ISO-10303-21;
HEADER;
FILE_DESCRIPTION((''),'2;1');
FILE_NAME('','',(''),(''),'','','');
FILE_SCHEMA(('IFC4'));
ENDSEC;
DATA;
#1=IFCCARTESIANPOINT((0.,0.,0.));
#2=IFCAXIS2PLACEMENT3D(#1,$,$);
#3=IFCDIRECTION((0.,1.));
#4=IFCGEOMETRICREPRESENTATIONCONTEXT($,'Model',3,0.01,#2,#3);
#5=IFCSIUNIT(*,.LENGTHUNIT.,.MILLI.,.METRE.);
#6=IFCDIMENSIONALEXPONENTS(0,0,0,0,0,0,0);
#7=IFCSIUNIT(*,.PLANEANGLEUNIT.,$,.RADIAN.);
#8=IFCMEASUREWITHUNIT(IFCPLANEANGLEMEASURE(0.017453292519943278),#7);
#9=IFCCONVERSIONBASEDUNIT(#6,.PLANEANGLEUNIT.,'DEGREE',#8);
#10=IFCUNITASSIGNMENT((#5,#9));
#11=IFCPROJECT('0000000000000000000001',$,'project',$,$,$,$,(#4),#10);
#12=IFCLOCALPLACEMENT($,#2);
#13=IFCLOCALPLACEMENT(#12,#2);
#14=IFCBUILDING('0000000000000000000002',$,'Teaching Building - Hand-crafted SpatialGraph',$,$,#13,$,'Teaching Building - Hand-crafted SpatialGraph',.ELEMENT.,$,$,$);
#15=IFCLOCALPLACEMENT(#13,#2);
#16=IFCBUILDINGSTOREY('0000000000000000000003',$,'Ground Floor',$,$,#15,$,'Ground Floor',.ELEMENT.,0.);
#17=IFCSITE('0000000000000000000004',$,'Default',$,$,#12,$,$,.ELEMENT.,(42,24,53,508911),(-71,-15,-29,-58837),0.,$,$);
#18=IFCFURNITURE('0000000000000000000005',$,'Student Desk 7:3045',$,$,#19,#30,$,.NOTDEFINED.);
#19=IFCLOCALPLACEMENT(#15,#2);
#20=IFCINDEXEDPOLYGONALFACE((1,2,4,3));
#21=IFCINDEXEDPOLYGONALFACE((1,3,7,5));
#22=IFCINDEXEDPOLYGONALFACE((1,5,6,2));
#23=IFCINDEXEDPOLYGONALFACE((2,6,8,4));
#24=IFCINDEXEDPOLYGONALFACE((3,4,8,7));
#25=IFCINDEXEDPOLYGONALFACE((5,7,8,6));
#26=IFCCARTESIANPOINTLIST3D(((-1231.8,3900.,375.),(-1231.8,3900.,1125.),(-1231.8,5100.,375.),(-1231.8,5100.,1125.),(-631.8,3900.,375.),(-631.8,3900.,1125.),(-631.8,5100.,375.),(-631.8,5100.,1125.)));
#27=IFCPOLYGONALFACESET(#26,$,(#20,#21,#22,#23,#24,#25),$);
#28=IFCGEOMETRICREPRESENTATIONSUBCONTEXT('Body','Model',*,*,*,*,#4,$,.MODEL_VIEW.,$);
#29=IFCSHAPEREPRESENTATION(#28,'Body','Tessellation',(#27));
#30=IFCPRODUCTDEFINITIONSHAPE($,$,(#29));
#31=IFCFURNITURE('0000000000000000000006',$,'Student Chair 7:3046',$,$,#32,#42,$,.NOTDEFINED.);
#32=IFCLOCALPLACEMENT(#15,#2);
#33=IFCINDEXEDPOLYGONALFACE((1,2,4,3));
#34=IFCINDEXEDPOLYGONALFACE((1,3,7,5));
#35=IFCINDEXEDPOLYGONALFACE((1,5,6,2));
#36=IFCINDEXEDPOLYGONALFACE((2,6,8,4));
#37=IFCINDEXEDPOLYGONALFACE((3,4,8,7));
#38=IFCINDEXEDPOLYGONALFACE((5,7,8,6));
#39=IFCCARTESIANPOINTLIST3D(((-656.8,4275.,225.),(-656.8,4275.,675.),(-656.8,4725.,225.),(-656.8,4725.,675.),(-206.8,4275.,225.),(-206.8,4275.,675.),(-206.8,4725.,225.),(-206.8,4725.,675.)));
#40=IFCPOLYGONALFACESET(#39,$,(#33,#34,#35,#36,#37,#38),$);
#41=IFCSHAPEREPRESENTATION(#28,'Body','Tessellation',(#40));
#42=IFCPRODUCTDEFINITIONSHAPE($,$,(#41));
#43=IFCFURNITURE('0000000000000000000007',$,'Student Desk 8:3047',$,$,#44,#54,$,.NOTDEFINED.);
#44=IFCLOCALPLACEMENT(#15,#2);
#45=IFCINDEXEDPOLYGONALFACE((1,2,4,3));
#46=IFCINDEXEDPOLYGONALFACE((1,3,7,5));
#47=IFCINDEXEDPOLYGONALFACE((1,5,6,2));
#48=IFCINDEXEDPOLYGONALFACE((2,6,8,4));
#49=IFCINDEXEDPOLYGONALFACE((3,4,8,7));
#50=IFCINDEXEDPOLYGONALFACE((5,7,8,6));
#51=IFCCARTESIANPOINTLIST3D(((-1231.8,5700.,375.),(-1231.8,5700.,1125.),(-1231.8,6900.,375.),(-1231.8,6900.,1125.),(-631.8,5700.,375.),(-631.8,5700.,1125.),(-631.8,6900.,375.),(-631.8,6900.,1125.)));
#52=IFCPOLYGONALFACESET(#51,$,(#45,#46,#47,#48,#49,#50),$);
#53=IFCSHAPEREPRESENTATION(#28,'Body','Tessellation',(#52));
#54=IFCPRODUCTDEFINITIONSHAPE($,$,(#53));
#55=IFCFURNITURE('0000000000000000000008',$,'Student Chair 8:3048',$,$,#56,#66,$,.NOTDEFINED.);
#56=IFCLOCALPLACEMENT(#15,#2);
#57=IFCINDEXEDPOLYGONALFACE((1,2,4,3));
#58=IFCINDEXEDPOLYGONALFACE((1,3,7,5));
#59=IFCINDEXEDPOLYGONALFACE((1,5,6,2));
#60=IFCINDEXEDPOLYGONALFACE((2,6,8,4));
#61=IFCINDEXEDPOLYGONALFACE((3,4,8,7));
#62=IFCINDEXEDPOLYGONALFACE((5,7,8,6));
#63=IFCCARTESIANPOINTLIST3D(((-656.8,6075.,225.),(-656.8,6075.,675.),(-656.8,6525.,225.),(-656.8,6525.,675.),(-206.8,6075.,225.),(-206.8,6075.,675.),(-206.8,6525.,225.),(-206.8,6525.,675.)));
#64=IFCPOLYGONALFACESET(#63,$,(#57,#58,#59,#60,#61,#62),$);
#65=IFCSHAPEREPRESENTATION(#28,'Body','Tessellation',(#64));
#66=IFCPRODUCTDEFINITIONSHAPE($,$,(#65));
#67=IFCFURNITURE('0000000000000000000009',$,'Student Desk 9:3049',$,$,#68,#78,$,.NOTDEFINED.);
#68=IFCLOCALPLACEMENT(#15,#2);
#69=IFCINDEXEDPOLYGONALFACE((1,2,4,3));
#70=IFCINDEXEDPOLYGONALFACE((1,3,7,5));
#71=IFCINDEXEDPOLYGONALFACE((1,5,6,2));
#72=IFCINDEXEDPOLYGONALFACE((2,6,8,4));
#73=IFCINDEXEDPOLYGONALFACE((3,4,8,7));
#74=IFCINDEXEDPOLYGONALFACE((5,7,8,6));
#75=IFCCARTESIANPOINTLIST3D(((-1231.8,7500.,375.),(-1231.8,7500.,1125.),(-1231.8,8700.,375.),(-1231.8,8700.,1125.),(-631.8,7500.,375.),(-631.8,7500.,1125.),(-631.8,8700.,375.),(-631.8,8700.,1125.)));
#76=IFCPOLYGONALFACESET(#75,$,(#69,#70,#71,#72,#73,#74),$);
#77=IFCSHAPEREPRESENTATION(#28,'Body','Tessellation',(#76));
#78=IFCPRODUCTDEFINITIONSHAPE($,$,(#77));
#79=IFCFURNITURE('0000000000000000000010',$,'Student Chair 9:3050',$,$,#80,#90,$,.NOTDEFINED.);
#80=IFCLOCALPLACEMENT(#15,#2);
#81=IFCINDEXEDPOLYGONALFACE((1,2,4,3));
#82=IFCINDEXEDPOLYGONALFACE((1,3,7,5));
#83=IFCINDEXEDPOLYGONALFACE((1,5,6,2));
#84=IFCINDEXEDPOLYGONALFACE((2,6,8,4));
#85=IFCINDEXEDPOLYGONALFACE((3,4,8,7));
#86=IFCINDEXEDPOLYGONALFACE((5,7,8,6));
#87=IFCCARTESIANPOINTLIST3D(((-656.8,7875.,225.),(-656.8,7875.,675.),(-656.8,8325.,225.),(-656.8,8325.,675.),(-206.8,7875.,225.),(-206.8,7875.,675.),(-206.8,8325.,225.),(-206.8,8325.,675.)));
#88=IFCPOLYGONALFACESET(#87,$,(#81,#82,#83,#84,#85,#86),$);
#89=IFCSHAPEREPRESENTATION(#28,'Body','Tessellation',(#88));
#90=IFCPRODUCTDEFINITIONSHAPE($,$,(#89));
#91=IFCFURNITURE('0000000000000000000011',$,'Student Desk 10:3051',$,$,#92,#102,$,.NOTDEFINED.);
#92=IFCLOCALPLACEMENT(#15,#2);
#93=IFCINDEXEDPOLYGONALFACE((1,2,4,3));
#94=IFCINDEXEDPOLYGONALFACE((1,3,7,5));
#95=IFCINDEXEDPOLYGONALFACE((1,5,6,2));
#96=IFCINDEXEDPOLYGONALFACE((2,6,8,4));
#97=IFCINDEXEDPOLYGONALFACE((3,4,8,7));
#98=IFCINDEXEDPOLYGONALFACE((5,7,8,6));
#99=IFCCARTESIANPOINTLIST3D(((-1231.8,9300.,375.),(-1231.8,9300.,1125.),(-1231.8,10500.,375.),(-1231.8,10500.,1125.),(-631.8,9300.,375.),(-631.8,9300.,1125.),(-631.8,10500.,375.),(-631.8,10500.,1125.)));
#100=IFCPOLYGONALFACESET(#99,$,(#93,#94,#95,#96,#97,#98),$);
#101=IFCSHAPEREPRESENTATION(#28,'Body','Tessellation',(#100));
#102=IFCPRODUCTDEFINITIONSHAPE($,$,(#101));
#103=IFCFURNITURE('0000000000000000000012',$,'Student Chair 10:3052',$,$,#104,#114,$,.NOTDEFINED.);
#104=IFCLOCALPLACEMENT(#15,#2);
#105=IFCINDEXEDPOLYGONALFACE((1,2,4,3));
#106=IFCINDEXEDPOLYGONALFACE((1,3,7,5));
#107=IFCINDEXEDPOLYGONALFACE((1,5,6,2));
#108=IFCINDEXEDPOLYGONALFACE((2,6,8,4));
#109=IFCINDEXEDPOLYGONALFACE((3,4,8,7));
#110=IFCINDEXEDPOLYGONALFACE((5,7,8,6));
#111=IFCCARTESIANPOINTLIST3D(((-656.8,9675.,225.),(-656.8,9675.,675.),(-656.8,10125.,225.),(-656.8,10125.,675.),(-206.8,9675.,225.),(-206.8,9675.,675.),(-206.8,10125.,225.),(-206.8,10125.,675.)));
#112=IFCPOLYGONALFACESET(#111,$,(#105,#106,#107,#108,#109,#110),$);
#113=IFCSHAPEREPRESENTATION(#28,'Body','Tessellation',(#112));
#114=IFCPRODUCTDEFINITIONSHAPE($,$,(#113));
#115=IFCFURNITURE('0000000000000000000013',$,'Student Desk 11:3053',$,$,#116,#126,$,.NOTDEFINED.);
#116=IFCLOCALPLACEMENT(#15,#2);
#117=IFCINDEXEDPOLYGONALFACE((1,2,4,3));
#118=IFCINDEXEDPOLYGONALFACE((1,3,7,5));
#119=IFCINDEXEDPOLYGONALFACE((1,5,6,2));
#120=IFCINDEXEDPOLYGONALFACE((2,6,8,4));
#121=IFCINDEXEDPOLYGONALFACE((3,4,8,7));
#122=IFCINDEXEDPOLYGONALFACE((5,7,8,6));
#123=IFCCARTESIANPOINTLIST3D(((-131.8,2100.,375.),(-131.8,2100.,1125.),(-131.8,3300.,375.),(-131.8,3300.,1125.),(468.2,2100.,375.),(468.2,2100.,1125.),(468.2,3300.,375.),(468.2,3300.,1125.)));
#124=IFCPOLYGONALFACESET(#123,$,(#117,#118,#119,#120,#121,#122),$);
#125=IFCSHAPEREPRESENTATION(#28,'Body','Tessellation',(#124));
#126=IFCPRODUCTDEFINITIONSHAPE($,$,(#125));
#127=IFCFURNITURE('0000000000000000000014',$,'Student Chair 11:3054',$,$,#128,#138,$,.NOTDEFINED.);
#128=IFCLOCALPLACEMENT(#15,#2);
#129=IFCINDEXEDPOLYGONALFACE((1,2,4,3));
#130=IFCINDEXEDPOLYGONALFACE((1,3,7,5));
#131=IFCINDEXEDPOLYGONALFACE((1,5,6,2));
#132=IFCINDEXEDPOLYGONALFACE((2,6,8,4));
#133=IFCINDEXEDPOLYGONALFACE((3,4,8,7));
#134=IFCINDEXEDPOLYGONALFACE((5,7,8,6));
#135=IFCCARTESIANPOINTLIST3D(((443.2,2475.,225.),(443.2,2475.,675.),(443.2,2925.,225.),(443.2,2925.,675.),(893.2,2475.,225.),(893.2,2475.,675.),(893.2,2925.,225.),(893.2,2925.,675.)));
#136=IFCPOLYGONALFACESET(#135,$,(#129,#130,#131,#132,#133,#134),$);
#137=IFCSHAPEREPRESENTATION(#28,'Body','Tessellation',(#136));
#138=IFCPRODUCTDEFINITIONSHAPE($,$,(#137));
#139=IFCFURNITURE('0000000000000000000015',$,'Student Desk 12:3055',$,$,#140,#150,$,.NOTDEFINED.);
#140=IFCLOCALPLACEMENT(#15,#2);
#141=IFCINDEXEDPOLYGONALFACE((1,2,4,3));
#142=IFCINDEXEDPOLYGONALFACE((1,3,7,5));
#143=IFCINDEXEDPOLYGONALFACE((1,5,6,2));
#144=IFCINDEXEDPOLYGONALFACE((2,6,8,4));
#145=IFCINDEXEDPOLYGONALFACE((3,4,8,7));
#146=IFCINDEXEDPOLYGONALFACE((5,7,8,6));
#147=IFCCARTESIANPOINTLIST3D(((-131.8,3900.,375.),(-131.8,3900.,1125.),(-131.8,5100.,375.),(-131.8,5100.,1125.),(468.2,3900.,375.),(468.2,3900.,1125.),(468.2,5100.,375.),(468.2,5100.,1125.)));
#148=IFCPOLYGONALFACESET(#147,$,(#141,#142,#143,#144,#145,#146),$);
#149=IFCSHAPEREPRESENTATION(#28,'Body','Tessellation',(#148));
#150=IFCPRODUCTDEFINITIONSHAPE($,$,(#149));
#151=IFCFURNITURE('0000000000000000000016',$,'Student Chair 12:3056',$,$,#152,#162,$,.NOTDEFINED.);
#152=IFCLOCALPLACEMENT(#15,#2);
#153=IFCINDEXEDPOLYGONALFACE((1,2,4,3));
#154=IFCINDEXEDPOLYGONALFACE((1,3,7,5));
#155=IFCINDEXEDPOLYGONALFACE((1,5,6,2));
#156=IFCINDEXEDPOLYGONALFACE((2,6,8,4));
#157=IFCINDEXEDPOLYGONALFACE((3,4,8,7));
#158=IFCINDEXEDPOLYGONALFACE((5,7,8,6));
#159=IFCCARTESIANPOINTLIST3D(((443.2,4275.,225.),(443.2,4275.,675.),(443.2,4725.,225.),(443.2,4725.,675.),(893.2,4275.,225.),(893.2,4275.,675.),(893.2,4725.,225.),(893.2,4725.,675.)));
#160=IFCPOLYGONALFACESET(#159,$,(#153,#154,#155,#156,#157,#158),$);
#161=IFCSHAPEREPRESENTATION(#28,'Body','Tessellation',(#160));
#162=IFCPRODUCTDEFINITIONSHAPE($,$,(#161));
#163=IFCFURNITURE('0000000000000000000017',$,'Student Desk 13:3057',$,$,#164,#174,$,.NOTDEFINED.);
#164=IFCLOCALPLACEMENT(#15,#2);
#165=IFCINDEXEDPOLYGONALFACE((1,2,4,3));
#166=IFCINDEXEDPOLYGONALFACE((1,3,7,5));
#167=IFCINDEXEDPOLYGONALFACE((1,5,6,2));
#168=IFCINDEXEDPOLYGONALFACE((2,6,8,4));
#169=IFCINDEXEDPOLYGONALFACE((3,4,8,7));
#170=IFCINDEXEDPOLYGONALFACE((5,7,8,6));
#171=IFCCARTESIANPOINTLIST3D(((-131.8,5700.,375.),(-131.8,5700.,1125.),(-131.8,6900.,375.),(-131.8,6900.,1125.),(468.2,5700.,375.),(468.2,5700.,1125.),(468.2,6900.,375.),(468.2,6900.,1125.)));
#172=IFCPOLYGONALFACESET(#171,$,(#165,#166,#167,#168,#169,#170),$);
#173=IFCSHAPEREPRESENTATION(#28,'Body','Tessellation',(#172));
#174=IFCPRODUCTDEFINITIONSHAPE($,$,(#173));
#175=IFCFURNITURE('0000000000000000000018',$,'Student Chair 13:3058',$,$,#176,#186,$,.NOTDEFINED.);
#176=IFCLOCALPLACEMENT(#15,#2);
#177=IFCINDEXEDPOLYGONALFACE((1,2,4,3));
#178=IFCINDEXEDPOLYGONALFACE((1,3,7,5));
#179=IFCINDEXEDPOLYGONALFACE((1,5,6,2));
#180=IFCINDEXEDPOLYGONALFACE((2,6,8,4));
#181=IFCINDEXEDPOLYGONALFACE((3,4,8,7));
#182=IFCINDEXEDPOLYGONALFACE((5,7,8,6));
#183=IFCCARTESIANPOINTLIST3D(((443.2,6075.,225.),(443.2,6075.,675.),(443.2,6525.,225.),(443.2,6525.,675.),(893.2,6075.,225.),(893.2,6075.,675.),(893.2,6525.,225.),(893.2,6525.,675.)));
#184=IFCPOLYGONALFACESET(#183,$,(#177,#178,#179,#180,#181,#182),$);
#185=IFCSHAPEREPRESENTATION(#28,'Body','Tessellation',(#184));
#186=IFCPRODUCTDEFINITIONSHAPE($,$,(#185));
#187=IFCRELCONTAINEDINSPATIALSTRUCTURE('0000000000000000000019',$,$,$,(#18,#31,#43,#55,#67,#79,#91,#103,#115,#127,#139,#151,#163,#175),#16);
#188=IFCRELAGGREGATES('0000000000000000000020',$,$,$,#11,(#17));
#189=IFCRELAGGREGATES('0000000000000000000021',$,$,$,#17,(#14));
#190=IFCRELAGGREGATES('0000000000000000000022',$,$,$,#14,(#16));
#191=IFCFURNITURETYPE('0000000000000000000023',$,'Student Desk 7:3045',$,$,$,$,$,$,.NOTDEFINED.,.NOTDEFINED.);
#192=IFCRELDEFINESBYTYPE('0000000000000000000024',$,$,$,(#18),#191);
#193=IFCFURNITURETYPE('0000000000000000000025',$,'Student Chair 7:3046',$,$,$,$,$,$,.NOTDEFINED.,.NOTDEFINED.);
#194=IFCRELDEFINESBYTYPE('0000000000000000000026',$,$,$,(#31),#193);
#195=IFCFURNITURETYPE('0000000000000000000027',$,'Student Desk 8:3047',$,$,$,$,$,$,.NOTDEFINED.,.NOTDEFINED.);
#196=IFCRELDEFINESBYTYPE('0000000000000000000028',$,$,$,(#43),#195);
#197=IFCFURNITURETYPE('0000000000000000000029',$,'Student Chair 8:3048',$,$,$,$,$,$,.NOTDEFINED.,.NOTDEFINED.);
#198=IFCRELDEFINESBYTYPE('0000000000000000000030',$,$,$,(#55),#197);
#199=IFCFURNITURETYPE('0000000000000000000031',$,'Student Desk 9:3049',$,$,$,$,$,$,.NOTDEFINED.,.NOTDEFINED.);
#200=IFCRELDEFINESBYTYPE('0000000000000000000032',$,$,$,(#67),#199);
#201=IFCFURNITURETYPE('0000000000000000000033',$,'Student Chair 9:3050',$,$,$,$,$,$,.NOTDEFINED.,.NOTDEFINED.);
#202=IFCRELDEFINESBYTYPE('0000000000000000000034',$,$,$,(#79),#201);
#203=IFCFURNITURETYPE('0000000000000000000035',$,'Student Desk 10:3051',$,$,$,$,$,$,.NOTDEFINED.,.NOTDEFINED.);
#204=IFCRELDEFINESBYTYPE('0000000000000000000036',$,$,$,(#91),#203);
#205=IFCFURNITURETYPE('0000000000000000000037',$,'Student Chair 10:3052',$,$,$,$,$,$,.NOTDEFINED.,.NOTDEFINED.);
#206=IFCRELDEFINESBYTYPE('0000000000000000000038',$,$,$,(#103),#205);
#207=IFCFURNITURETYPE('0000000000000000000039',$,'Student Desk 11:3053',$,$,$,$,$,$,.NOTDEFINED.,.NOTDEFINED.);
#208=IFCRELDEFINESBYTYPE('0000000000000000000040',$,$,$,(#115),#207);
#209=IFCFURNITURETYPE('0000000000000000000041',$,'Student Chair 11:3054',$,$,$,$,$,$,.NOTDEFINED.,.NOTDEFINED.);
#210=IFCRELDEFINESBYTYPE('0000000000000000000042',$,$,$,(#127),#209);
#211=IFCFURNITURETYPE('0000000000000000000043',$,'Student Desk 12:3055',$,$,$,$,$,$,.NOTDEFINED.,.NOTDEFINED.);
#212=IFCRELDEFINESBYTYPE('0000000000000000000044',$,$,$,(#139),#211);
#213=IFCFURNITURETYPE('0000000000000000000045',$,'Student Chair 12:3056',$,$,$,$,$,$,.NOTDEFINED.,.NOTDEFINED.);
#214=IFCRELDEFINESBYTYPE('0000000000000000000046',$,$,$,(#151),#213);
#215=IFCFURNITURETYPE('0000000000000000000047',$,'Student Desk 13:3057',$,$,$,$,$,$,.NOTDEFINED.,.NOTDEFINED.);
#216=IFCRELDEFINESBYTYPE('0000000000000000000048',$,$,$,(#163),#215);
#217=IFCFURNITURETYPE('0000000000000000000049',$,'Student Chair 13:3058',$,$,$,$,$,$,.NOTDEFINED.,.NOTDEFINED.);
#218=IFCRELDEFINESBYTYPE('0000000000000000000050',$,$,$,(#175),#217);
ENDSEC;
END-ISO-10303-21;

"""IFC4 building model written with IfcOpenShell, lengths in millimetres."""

from ifc_helpers import new_model, entity, si_unit, converted_unit, direction, frame, frame_2d, origin, origin_2d_with_axis, place, context, subcontext, project, spatial, rectangle, extrude, type_object, element, save


model = new_model("IFC4")

# Units and contexts
model_context = context("Model", 3, precision=0.01, world=origin(), true_north=direction((0.0, 1.0)))
body_context = subcontext(model_context, "Body", "Model", "MODEL_VIEW")
ifc_project = project(units=[si_unit("LENGTHUNIT", "METRE", prefix="MILLI"), converted_unit("PLANEANGLEUNIT", "DEGREE", entity("IfcPlaneAngleMeasure", 0.017453292519943278), si_unit("PLANEANGLEUNIT", "RADIAN"), dimensions=[0, 0, 0, 0, 0, 0, 0])], contexts=[model_context])

# Site, building, storey
site_placement = place(None, origin())
site = spatial("IfcSite", under=ifc_project, at=site_placement, Name="Default", CompositionType="ELEMENT", RefLatitude=(42, 24, 53, 508911), RefLongitude=(-71, -15, -29, -58837), RefElevation=0.0)
building_placement = place(site_placement, origin())
building = spatial("IfcBuilding", under=site, at=building_placement, Name="Teaching Building - Hand-crafted SpatialGraph", LongName="Teaching Building - Hand-crafted SpatialGraph", CompositionType="ELEMENT")
storey_placement = place(building_placement, origin())
storey = spatial("IfcBuildingStorey", under=building, at=storey_placement, Name="Ground Floor", LongName="Ground Floor", CompositionType="ELEMENT", Elevation=0.0)

# Furniture
furniture_type_1 = type_object("IfcFurnitureType", Name="Student Desk 7:3045", PredefinedType="NOTDEFINED")
furniture_1_placement = place(storey_placement, origin())
element("IfcFurniture", 1, at=furniture_1_placement, inside=storey, type_object=furniture_type_1, Name="Student Desk 7:3045", PredefinedType="NOTDEFINED", context=body_context, shape_type="SweptSolid", body=[
    extrude(rectangle(XDim=1200.0, YDim=600.0, at=frame_2d((0.0, 0.0), x_axis=(1.0, 0.0))), frame((-931.8, 4500.0, 375.0), z_axis=(0.0, 0.0, 1.0), x_axis=(0.0, 1.0, 0.0)), (0.0, 0.0, 1.0), 750.0),
])
furniture_type_2 = type_object("IfcFurnitureType", Name="Student Chair 7:3046", PredefinedType="NOTDEFINED")
furniture_2_placement = place(storey_placement, origin())
element("IfcFurniture", 2, at=furniture_2_placement, inside=storey, type_object=furniture_type_2, Name="Student Chair 7:3046", PredefinedType="NOTDEFINED", context=body_context, shape_type="SweptSolid", body=[
    extrude(rectangle(XDim=450.0, YDim=450.0, at=origin_2d_with_axis()), frame((-431.8, 4500.0, 225.0)), (0.0, 0.0, 1.0), 450.0),
])
furniture_type_3 = type_object("IfcFurnitureType", Name="Student Desk 8:3047", PredefinedType="NOTDEFINED")
furniture_3_placement = place(storey_placement, origin())
element("IfcFurniture", 3, at=furniture_3_placement, inside=storey, type_object=furniture_type_3, Name="Student Desk 8:3047", PredefinedType="NOTDEFINED", context=body_context, shape_type="SweptSolid", body=[
    extrude(rectangle(XDim=1200.0, YDim=600.0, at=frame_2d((0.0, 0.0), x_axis=(1.0, 0.0))), frame((-931.8, 6300.0, 375.0), z_axis=(0.0, 0.0, 1.0), x_axis=(0.0, 1.0, 0.0)), (0.0, 0.0, 1.0), 750.0),
])
furniture_type_4 = type_object("IfcFurnitureType", Name="Student Chair 8:3048", PredefinedType="NOTDEFINED")
furniture_4_placement = place(storey_placement, origin())
element("IfcFurniture", 4, at=furniture_4_placement, inside=storey, type_object=furniture_type_4, Name="Student Chair 8:3048", PredefinedType="NOTDEFINED", context=body_context, shape_type="SweptSolid", body=[
    extrude(rectangle(XDim=450.0, YDim=450.0, at=origin_2d_with_axis()), frame((-431.8, 6300.0, 225.0)), (0.0, 0.0, 1.0), 450.0),
])
furniture_type_5 = type_object("IfcFurnitureType", Name="Student Desk 9:3049", PredefinedType="NOTDEFINED")
furniture_5_placement = place(storey_placement, origin())
element("IfcFurniture", 5, at=furniture_5_placement, inside=storey, type_object=furniture_type_5, Name="Student Desk 9:3049", PredefinedType="NOTDEFINED", context=body_context, shape_type="SweptSolid", body=[
    extrude(rectangle(XDim=1200.0, YDim=600.0, at=frame_2d((0.0, 0.0), x_axis=(1.0, 0.0))), frame((-931.8, 8100.0, 375.0), z_axis=(0.0, 0.0, 1.0), x_axis=(0.0, 1.0, 0.0)), (0.0, 0.0, 1.0), 750.0),
])
furniture_type_6 = type_object("IfcFurnitureType", Name="Student Chair 9:3050", PredefinedType="NOTDEFINED")
furniture_6_placement = place(storey_placement, origin())
element("IfcFurniture", 6, at=furniture_6_placement, inside=storey, type_object=furniture_type_6, Name="Student Chair 9:3050", PredefinedType="NOTDEFINED", context=body_context, shape_type="SweptSolid", body=[
    extrude(rectangle(XDim=450.0, YDim=450.0, at=origin_2d_with_axis()), frame((-431.8, 8100.0, 225.0)), (0.0, 0.0, 1.0), 450.0),
])
furniture_type_7 = type_object("IfcFurnitureType", Name="Student Desk 10:3051", PredefinedType="NOTDEFINED")
furniture_7_placement = place(storey_placement, origin())
element("IfcFurniture", 7, at=furniture_7_placement, inside=storey, type_object=furniture_type_7, Name="Student Desk 10:3051", PredefinedType="NOTDEFINED", context=body_context, shape_type="SweptSolid", body=[
    extrude(rectangle(XDim=1200.0, YDim=600.0, at=frame_2d((0.0, 0.0), x_axis=(1.0, 0.0))), frame((-931.8, 9900.0, 375.0), z_axis=(0.0, 0.0, 1.0), x_axis=(0.0, 1.0, 0.0)), (0.0, 0.0, 1.0), 750.0),
])
furniture_type_8 = type_object("IfcFurnitureType", Name="Student Chair 10:3052", PredefinedType="NOTDEFINED")
furniture_8_placement = place(storey_placement, origin())
element("IfcFurniture", 8, at=furniture_8_placement, inside=storey, type_object=furniture_type_8, Name="Student Chair 10:3052", PredefinedType="NOTDEFINED", context=body_context, shape_type="SweptSolid", body=[
    extrude(rectangle(XDim=450.0, YDim=450.0, at=frame_2d((0.0, 0.0), x_axis=(1.0, 0.0))), frame((-431.8, 9900.0, 225.0)), (0.0, 0.0, 1.0), 450.0),
])
furniture_type_9 = type_object("IfcFurnitureType", Name="Student Desk 11:3053", PredefinedType="NOTDEFINED")
furniture_9_placement = place(storey_placement, origin())
element("IfcFurniture", 9, at=furniture_9_placement, inside=storey, type_object=furniture_type_9, Name="Student Desk 11:3053", PredefinedType="NOTDEFINED", context=body_context, shape_type="SweptSolid", body=[
    extrude(rectangle(XDim=1200.0, YDim=600.0, at=origin_2d_with_axis()), frame((168.2, 2700.0, 375.0), z_axis=(0.0, 0.0, 1.0), x_axis=(0.0, 1.0, 0.0)), (0.0, 0.0, 1.0), 750.0),
])
furniture_type_10 = type_object("IfcFurnitureType", Name="Student Chair 11:3054", PredefinedType="NOTDEFINED")
furniture_10_placement = place(storey_placement, origin())
element("IfcFurniture", 10, at=furniture_10_placement, inside=storey, type_object=furniture_type_10, Name="Student Chair 11:3054", PredefinedType="NOTDEFINED", context=body_context, shape_type="SweptSolid", body=[
    extrude(rectangle(XDim=450.0, YDim=450.0, at=origin_2d_with_axis()), frame((668.2, 2700.0, 225.0)), (0.0, 0.0, 1.0), 450.0),
])
furniture_type_11 = type_object("IfcFurnitureType", Name="Student Desk 12:3055", PredefinedType="NOTDEFINED")
furniture_11_placement = place(storey_placement, origin())
element("IfcFurniture", 11, at=furniture_11_placement, inside=storey, type_object=furniture_type_11, Name="Student Desk 12:3055", PredefinedType="NOTDEFINED", context=body_context, shape_type="SweptSolid", body=[
    extrude(rectangle(XDim=1200.0, YDim=600.0, at=frame_2d((0.0, 0.0), x_axis=(1.0, 0.0))), frame((168.2, 4500.0, 375.0), z_axis=(0.0, 0.0, 1.0), x_axis=(0.0, 1.0, 0.0)), (0.0, 0.0, 1.0), 750.0),
])
furniture_type_12 = type_object("IfcFurnitureType", Name="Student Chair 12:3056", PredefinedType="NOTDEFINED")
furniture_12_placement = place(storey_placement, origin())
element("IfcFurniture", 12, at=furniture_12_placement, inside=storey, type_object=furniture_type_12, Name="Student Chair 12:3056", PredefinedType="NOTDEFINED", context=body_context, shape_type="SweptSolid", body=[
    extrude(rectangle(XDim=450.0, YDim=450.0, at=origin_2d_with_axis()), frame((668.2, 4500.0, 225.0)), (0.0, 0.0, 1.0), 450.0),
])
furniture_type_13 = type_object("IfcFurnitureType", Name="Student Desk 13:3057", PredefinedType="NOTDEFINED")
furniture_13_placement = place(storey_placement, origin())
element("IfcFurniture", 13, at=furniture_13_placement, inside=storey, type_object=furniture_type_13, Name="Student Desk 13:3057", PredefinedType="NOTDEFINED", context=body_context, shape_type="SweptSolid", body=[
    extrude(rectangle(XDim=1200.0, YDim=600.0, at=origin_2d_with_axis()), frame((168.2, 6300.0, 375.0), z_axis=(0.0, 0.0, 1.0), x_axis=(0.0, 1.0, 0.0)), (0.0, 0.0, 1.0), 750.0),
])
furniture_type_14 = type_object("IfcFurnitureType", Name="Student Chair 13:3058", PredefinedType="NOTDEFINED")
furniture_14_placement = place(storey_placement, origin())
element("IfcFurniture", 14, at=furniture_14_placement, inside=storey, type_object=furniture_type_14, Name="Student Chair 13:3058", PredefinedType="NOTDEFINED", context=body_context, shape_type="SweptSolid", body=[
    extrude(rectangle(XDim=450.0, YDim=450.0, at=origin_2d_with_axis()), frame((668.2, 6300.0, 225.0)), (0.0, 0.0, 1.0), 450.0),
])

save(model, "model.ifc")
